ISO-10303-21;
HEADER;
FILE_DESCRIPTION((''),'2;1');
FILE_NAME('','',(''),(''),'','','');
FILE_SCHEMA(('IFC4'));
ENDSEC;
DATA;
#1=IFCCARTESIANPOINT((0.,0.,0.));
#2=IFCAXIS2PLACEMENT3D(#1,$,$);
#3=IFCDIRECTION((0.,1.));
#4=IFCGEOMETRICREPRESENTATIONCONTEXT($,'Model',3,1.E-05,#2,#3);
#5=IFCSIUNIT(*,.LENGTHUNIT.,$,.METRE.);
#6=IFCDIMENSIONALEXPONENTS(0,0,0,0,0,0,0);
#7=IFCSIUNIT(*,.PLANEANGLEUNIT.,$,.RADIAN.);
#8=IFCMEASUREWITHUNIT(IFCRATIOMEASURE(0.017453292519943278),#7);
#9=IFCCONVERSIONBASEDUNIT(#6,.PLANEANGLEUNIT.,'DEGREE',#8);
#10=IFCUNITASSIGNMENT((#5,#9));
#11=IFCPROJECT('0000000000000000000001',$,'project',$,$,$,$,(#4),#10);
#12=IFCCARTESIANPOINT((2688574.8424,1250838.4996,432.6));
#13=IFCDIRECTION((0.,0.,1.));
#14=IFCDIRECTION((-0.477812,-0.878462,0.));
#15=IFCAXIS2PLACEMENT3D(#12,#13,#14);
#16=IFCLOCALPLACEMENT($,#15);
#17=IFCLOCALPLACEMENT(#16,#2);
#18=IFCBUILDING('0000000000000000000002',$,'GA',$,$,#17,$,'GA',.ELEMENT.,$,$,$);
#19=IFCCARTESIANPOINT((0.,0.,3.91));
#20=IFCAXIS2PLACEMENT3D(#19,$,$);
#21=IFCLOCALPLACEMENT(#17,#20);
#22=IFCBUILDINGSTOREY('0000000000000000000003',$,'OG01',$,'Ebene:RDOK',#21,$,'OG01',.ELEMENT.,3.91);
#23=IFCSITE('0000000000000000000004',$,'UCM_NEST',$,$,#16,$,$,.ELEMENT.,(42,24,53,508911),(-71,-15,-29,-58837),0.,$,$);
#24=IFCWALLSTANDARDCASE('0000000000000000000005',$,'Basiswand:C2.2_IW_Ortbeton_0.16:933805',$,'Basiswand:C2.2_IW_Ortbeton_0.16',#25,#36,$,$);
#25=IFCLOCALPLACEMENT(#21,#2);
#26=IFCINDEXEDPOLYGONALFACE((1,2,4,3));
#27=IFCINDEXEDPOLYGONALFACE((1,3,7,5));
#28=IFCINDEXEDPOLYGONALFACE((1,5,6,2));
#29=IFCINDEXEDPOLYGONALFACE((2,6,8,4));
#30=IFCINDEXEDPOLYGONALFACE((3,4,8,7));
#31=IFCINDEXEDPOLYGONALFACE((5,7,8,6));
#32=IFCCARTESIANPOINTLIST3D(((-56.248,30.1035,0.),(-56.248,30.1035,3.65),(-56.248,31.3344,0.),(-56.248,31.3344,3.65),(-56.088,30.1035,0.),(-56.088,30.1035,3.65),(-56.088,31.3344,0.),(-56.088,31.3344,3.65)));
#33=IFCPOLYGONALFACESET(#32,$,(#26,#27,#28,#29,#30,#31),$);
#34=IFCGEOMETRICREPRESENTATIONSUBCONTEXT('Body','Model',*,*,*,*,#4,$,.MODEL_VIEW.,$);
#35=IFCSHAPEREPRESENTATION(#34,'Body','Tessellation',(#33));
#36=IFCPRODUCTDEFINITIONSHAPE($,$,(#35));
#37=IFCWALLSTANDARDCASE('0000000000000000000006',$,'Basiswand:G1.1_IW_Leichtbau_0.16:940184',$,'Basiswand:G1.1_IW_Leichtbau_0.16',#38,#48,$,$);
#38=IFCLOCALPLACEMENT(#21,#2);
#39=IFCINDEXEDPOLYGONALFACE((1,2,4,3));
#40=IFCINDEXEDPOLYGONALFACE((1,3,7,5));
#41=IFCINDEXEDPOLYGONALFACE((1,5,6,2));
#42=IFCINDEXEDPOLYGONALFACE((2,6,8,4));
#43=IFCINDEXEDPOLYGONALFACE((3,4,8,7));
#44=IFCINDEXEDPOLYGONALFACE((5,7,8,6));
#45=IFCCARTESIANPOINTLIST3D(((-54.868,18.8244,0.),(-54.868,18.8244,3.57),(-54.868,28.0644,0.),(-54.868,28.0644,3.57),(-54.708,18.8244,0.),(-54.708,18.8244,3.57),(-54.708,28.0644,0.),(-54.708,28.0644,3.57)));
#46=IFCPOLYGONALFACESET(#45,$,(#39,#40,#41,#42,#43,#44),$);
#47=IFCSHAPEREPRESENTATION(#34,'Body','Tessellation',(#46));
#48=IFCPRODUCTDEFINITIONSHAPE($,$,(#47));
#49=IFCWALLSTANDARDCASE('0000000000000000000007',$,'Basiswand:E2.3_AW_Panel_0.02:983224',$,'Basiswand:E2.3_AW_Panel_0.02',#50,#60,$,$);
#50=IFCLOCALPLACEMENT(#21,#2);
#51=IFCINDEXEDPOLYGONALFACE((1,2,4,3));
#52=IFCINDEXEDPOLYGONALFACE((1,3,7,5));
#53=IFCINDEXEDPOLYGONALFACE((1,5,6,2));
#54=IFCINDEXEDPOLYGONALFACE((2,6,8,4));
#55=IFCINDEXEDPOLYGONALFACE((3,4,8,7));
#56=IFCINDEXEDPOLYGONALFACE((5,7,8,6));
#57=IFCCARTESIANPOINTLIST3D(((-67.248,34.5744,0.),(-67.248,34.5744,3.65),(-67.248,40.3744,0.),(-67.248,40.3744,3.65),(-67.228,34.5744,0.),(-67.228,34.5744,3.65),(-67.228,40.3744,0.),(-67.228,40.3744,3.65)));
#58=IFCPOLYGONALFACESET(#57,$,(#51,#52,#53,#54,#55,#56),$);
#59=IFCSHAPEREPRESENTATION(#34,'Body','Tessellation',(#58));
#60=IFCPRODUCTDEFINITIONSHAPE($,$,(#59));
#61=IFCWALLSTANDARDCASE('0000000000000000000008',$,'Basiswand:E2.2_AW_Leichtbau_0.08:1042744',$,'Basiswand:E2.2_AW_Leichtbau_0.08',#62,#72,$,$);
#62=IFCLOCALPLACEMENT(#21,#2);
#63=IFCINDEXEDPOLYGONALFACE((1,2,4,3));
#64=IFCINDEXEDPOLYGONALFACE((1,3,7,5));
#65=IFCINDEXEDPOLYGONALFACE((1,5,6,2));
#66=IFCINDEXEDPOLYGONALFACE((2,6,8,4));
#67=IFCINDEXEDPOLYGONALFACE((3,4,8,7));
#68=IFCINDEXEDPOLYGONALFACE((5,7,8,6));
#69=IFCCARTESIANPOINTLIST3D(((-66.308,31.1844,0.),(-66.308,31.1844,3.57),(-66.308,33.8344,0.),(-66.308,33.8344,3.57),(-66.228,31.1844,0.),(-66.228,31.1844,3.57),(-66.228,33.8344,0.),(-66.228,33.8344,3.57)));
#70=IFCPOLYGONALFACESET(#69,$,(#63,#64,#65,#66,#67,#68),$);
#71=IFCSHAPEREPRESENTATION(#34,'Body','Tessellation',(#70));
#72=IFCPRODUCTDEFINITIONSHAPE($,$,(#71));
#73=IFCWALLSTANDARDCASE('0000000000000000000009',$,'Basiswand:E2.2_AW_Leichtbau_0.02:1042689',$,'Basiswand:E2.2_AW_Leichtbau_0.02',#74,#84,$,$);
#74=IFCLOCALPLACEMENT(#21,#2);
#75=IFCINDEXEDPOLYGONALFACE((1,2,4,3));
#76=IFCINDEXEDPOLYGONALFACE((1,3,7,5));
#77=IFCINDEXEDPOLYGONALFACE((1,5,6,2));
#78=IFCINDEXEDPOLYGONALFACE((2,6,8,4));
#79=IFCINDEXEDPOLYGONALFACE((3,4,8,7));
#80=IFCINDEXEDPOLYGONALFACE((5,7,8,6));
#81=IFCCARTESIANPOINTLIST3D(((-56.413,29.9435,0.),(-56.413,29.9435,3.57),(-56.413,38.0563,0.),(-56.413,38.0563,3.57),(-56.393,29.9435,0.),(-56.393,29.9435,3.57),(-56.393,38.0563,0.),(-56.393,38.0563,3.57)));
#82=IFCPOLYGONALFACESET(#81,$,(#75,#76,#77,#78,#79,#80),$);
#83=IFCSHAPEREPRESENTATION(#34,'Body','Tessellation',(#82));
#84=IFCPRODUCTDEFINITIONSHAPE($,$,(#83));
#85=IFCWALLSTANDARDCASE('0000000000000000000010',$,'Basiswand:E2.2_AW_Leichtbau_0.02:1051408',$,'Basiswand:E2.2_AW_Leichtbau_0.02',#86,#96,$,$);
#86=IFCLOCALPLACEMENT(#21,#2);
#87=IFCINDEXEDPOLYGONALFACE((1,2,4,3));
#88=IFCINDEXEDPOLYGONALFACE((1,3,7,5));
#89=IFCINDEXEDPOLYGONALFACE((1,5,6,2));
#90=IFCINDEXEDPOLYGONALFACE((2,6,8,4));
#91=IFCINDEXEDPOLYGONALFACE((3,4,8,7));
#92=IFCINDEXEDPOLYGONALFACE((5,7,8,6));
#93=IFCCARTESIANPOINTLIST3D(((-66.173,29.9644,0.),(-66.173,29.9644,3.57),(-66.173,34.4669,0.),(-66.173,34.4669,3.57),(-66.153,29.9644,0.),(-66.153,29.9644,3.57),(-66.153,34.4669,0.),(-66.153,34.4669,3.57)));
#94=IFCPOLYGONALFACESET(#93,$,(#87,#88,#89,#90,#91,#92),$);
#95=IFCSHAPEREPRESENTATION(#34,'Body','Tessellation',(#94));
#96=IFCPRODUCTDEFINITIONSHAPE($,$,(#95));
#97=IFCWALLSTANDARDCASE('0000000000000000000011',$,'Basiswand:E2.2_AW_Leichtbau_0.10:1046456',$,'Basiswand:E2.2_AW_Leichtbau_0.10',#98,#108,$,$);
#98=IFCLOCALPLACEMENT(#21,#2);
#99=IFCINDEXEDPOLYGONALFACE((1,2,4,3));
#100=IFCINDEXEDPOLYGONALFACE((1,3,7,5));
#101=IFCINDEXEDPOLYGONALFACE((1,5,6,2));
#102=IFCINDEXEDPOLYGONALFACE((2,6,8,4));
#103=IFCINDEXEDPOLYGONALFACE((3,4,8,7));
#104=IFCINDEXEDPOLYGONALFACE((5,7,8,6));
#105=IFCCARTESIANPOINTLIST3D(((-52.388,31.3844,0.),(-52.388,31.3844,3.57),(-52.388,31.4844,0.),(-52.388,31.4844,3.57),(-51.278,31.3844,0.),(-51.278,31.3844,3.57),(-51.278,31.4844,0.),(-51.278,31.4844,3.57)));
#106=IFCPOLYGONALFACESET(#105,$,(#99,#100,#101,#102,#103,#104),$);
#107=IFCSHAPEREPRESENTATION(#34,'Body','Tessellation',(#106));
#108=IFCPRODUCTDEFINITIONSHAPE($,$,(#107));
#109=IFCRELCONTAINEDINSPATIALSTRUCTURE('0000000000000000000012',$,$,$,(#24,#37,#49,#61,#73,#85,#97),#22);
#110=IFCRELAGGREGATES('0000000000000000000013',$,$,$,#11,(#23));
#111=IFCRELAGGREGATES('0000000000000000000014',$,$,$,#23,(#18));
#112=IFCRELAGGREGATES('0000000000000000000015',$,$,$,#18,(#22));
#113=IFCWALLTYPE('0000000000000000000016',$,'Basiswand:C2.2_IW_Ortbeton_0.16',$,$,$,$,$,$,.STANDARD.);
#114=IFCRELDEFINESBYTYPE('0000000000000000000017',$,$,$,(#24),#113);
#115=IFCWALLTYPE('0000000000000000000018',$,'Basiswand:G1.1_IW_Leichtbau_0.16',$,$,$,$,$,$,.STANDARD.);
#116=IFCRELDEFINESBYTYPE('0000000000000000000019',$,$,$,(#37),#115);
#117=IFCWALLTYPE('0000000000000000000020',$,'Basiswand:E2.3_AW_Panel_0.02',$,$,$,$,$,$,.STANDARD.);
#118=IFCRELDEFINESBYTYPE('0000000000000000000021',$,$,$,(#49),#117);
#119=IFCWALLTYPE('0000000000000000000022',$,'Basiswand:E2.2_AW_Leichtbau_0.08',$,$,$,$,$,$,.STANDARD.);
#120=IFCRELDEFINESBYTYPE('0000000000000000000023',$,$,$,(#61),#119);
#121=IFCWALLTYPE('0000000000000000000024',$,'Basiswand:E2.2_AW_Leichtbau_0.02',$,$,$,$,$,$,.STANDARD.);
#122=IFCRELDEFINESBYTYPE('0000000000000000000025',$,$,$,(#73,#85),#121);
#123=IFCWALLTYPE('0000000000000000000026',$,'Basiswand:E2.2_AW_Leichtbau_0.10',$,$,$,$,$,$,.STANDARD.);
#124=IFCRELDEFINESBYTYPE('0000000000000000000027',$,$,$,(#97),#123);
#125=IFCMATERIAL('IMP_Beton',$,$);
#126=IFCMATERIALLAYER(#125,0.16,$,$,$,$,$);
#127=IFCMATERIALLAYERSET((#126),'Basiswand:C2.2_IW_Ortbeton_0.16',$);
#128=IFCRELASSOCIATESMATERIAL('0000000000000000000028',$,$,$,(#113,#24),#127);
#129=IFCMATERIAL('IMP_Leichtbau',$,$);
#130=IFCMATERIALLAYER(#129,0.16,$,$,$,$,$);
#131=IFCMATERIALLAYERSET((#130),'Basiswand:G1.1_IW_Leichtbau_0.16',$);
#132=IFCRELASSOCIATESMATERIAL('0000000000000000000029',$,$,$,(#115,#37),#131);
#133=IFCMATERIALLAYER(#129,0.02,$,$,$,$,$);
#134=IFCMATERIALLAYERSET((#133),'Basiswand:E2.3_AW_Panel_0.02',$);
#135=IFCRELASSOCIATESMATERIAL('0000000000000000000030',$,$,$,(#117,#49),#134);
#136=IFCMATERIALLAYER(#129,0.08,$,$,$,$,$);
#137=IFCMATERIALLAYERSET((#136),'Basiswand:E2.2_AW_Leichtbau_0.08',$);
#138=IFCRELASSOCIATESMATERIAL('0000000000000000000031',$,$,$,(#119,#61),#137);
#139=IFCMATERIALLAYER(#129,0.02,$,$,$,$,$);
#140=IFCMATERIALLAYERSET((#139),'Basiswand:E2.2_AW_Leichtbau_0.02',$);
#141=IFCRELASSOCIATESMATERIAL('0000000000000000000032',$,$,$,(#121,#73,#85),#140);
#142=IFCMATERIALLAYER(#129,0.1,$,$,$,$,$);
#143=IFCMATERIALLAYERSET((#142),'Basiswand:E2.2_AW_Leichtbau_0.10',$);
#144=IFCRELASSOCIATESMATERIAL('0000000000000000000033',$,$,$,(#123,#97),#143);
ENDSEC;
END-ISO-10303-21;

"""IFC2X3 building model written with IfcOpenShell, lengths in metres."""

from ifc_helpers import new_model, entity, si_unit, converted_unit, direction, frame, frame_2d, origin, place, context, subcontext, project, spatial, polyline, rectangle, extrude, clip, bounded_halfspace, material, layer, layer_set, layer_usage, type_object, element, save


model = new_model("IFC2X3")

# Units and contexts
model_context = context("Model", 3, precision=1e-05, world=origin(), true_north=direction((0.0, 1.0)))
body_context = subcontext(model_context, "Body", "Model", "MODEL_VIEW")
ifc_project = project(units=[si_unit("LENGTHUNIT", "METRE"), converted_unit("PLANEANGLEUNIT", "DEGREE", entity("IfcRatioMeasure", 0.017453292519943278), si_unit("PLANEANGLEUNIT", "RADIAN"), dimensions=[0, 0, 0, 0, 0, 0, 0])], contexts=[model_context])

# Site, building, storey
site_placement = place(None, frame((2688574.8424, 1250838.4996, 432.6), z_axis=(0.0, 0.0, 1.0), x_axis=(-0.477812, -0.878462, 0.0)))
site = spatial("IfcSite", under=ifc_project, at=site_placement, Name="UCM_NEST", CompositionType="ELEMENT", RefLatitude=(42, 24, 53, 508911), RefLongitude=(-71, -15, -29, -58837), RefElevation=0.0)
building_placement = place(site_placement, origin())
building = spatial("IfcBuilding", under=site, at=building_placement, Name="GA", LongName="GA", CompositionType="ELEMENT")
storey_placement = place(building_placement, frame((0.0, 0.0, 3.91)))
storey = spatial("IfcBuildingStorey", under=building, at=storey_placement, Name="OG01", ObjectType="Ebene:RDOK", LongName="OG01", CompositionType="ELEMENT", Elevation=3.91)

# Shared definitions
ifc_material_1 = material(Name="IMP_Beton")

# Shared definitions
ifc_material_2 = material(Name="IMP_Leichtbau")

# Wall
ifc_layer_1 = layer(ifc_material_1, 0.16)
ifc_layer_set_1 = layer_set([ifc_layer_1], Name="Basiswand:C2.2_IW_Ortbeton_0.16")
ifc_layer_usage_1 = layer_usage(ifc_layer_set_1, "AXIS2", "NEGATIVE", 0.08)
wall_type_1 = type_object("IfcWallType", Name="Basiswand:C2.2_IW_Ortbeton_0.16", PredefinedType="STANDARD", material=ifc_layer_set_1)
wall_1_placement = place(storey_placement, frame((-56.168, 31.3344, 0.0), z_axis=(0.0, 0.0, 1.0), x_axis=(0.0, -1.0, 0.0)))
element("IfcWallStandardCase", 1, at=wall_1_placement, inside=storey, type_object=wall_type_1, material=ifc_layer_usage_1, Name="Basiswand:C2.2_IW_Ortbeton_0.16:933805", ObjectType="Basiswand:C2.2_IW_Ortbeton_0.16", context=body_context, shape_type="SweptSolid", body=[
    extrude(rectangle(XDim=1.2309, YDim=0.16, at=frame_2d((0.6155, 0.0), x_axis=(-1.0, 0.0))), origin(), (0.0, 0.0, 1.0), 3.65),
])

# Shared definitions
ifc_layer_2 = layer(ifc_material_2, 0.16)
ifc_layer_set_2 = layer_set([ifc_layer_2], Name="Basiswand:G1.1_IW_Leichtbau_0.16")
ifc_layer_usage_2 = layer_usage(ifc_layer_set_2, "AXIS2", "NEGATIVE", 0.08)
wall_type_2 = type_object("IfcWallType", Name="Basiswand:G1.1_IW_Leichtbau_0.16", PredefinedType="STANDARD", material=ifc_layer_set_2)

# Walls
wall_2_placement = place(storey_placement, frame((-54.788, 28.0644, 0.0), z_axis=(0.0, 0.0, 1.0), x_axis=(0.0, -1.0, 0.0)))
element("IfcWallStandardCase", 2, at=wall_2_placement, inside=storey, type_object=wall_type_2, material=ifc_layer_usage_2, Name="Basiswand:G1.1_IW_Leichtbau_0.16:940184", ObjectType="Basiswand:G1.1_IW_Leichtbau_0.16", context=body_context, shape_type="Clipping", body=[
    clip(extrude(rectangle(XDim=9.24, YDim=0.16, at=frame_2d((4.62, 0.0), x_axis=(-1.0, 0.0))), origin(), (0.0, 0.0, 1.0), 3.57), bounded_halfspace(frame((0.0, -0.08, 3.57), z_axis=(0.0, 0.0, -1.0), x_axis=(1.0, 0.0, 0.0)), True, frame((0.0, -0.08, 3.57), z_axis=(0.0, 0.0, -1.0), x_axis=(1.0, 0.0, 0.0)), polyline([(0.0, 0.0), (0.0, -0.16), (9.24, -0.16), (9.24, 0.0), (0.0, 0.0)]))),
])
ifc_layer_3 = layer(ifc_material_2, 0.02)
ifc_layer_set_3 = layer_set([ifc_layer_3], Name="Basiswand:E2.3_AW_Panel_0.02")
ifc_layer_usage_3 = layer_usage(ifc_layer_set_3, "AXIS2", "NEGATIVE", 0.01)
wall_type_3 = type_object("IfcWallType", Name="Basiswand:E2.3_AW_Panel_0.02", PredefinedType="STANDARD", material=ifc_layer_set_3)
wall_3_placement = place(storey_placement, frame((-67.238, 34.5744, 0.0), z_axis=(0.0, 0.0, 1.0), x_axis=(0.0, 1.0, 0.0)))
element("IfcWallStandardCase", 3, at=wall_3_placement, inside=storey, type_object=wall_type_3, material=ifc_layer_usage_3, Name="Basiswand:E2.3_AW_Panel_0.02:983224", ObjectType="Basiswand:E2.3_AW_Panel_0.02", context=body_context, shape_type="SweptSolid", body=[
    extrude(rectangle(XDim=5.8, YDim=0.02, at=frame_2d((2.9, 0.0), x_axis=(-1.0, 0.0))), origin(), (0.0, 0.0, 1.0), 3.65),
])

# Shared definitions
ifc_layer_4 = layer(ifc_material_2, 0.08)
ifc_layer_set_4 = layer_set([ifc_layer_4], Name="Basiswand:E2.2_AW_Leichtbau_0.08")
ifc_layer_usage_4 = layer_usage(ifc_layer_set_4, "AXIS2", "NEGATIVE", 0.04)
wall_type_4 = type_object("IfcWallType", Name="Basiswand:E2.2_AW_Leichtbau_0.08", PredefinedType="STANDARD", material=ifc_layer_set_4)

# Walls
wall_4_placement = place(storey_placement, frame((-66.268, 33.8344, 0.0), z_axis=(0.0, 0.0, 1.0), x_axis=(0.0, -1.0, 0.0)))
element("IfcWallStandardCase", 4, at=wall_4_placement, inside=storey, type_object=wall_type_4, material=ifc_layer_usage_4, Name="Basiswand:E2.2_AW_Leichtbau_0.08:1042744", ObjectType="Basiswand:E2.2_AW_Leichtbau_0.08", context=body_context, shape_type="Clipping", body=[
    clip(extrude(rectangle(XDim=2.65, YDim=0.08, at=frame_2d((1.325, 0.0), x_axis=(-1.0, 0.0))), origin(), (0.0, 0.0, 1.0), 3.57), bounded_halfspace(frame((0.0, -0.04, 3.57), z_axis=(0.0, 0.0, -1.0), x_axis=(1.0, 0.0, 0.0)), True, frame((0.0, -0.04, 3.57), z_axis=(0.0, 0.0, -1.0), x_axis=(1.0, 0.0, 0.0)), polyline([(0.0, 0.0), (0.0, -0.08), (2.65, -0.08), (2.65, 0.0), (0.0, 0.0)]))),
])
ifc_layer_5 = layer(ifc_material_2, 0.02)
ifc_layer_set_5 = layer_set([ifc_layer_5], Name="Basiswand:E2.2_AW_Leichtbau_0.02")
ifc_layer_usage_5 = layer_usage(ifc_layer_set_5, "AXIS2", "NEGATIVE", 0.01)
wall_type_5 = type_object("IfcWallType", Name="Basiswand:E2.2_AW_Leichtbau_0.02", PredefinedType="STANDARD", material=ifc_layer_set_5)
wall_5_placement = place(storey_placement, frame((-56.403, 29.9435, 0.0), z_axis=(0.0, 0.0, 1.0), x_axis=(0.0, 1.0, 0.0)))
element("IfcWallStandardCase", 5, at=wall_5_placement, inside=storey, type_object=wall_type_5, material=ifc_layer_usage_5, Name="Basiswand:E2.2_AW_Leichtbau_0.02:1042689", ObjectType="Basiswand:E2.2_AW_Leichtbau_0.02", context=body_context, shape_type="Clipping", body=[
    clip(extrude(rectangle(XDim=8.1128, YDim=0.02, at=frame_2d((4.0564, 0.0), x_axis=(-1.0, 0.0))), origin(), (0.0, 0.0, 1.0), 3.57), bounded_halfspace(frame((0.0, -0.01, 3.57), z_axis=(0.0, 0.0, -1.0), x_axis=(-1.0, 0.0, 0.0)), True, frame((0.0, -0.01, 3.57), z_axis=(0.0, 0.0, -1.0), x_axis=(-1.0, 0.0, 0.0)), polyline([(0.0, 0.0), (0.0, 0.02), (-8.1128, 0.02), (-8.1128, 0.0), (0.0, 0.0)]))),
])
wall_6_placement = place(storey_placement, frame((-66.163, 29.9644, 0.0), z_axis=(0.0, 0.0, 1.0), x_axis=(0.0, 1.0, 0.0)))
element("IfcWallStandardCase", 6, at=wall_6_placement, inside=storey, type_object=wall_type_5, material=ifc_layer_usage_5, Name="Basiswand:E2.2_AW_Leichtbau_0.02:1051408", ObjectType="Basiswand:E2.2_AW_Leichtbau_0.02", context=body_context, shape_type="Clipping", body=[
    clip(extrude(rectangle(XDim=4.5024, YDim=0.02, at=frame_2d((2.2512, 0.0), x_axis=(-1.0, 0.0))), origin(), (0.0, 0.0, 1.0), 3.57), bounded_halfspace(frame((0.0, -0.01, 3.57), z_axis=(0.0, 0.0, -1.0), x_axis=(-1.0, 0.0, 0.0)), True, frame((0.0, -0.01, 3.57), z_axis=(0.0, 0.0, -1.0), x_axis=(-1.0, 0.0, 0.0)), polyline([(0.0, 0.0), (0.0, 0.02), (-4.5024, 0.02), (-4.5024, 0.0), (0.0, 0.0)]))),
])
ifc_layer_6 = layer(ifc_material_2, 0.1)
ifc_layer_set_6 = layer_set([ifc_layer_6], Name="Basiswand:E2.2_AW_Leichtbau_0.10")
ifc_layer_usage_6 = layer_usage(ifc_layer_set_6, "AXIS2", "NEGATIVE", 0.05)
wall_type_6 = type_object("IfcWallType", Name="Basiswand:E2.2_AW_Leichtbau_0.10", PredefinedType="STANDARD", material=ifc_layer_set_6)
wall_7_placement = place(storey_placement, frame((-51.278, 31.4344, 0.0), z_axis=(0.0, 0.0, 1.0), x_axis=(-1.0, 0.0, 0.0)))
element("IfcWallStandardCase", 7, at=wall_7_placement, inside=storey, type_object=wall_type_6, material=ifc_layer_usage_6, Name="Basiswand:E2.2_AW_Leichtbau_0.10:1046456", ObjectType="Basiswand:E2.2_AW_Leichtbau_0.10", context=body_context, shape_type="Clipping", body=[
    clip(extrude(rectangle(XDim=1.11, YDim=0.1, at=frame_2d((0.555, 0.0), x_axis=(-1.0, 0.0))), origin(), (0.0, 0.0, 1.0), 3.57), bounded_halfspace(frame((0.0, -0.05, 3.57), z_axis=(0.0, 0.0, -1.0), x_axis=(0.0, 1.0, 0.0)), True, frame((0.0, -0.05, 3.57), z_axis=(0.0, 0.0, -1.0), x_axis=(0.0, 1.0, 0.0)), polyline([(0.0, 0.0), (0.1, 0.0), (0.1, 1.11), (0.0, 1.11), (0.0, 0.0)]))),
])

save(model, "model.ifc")
